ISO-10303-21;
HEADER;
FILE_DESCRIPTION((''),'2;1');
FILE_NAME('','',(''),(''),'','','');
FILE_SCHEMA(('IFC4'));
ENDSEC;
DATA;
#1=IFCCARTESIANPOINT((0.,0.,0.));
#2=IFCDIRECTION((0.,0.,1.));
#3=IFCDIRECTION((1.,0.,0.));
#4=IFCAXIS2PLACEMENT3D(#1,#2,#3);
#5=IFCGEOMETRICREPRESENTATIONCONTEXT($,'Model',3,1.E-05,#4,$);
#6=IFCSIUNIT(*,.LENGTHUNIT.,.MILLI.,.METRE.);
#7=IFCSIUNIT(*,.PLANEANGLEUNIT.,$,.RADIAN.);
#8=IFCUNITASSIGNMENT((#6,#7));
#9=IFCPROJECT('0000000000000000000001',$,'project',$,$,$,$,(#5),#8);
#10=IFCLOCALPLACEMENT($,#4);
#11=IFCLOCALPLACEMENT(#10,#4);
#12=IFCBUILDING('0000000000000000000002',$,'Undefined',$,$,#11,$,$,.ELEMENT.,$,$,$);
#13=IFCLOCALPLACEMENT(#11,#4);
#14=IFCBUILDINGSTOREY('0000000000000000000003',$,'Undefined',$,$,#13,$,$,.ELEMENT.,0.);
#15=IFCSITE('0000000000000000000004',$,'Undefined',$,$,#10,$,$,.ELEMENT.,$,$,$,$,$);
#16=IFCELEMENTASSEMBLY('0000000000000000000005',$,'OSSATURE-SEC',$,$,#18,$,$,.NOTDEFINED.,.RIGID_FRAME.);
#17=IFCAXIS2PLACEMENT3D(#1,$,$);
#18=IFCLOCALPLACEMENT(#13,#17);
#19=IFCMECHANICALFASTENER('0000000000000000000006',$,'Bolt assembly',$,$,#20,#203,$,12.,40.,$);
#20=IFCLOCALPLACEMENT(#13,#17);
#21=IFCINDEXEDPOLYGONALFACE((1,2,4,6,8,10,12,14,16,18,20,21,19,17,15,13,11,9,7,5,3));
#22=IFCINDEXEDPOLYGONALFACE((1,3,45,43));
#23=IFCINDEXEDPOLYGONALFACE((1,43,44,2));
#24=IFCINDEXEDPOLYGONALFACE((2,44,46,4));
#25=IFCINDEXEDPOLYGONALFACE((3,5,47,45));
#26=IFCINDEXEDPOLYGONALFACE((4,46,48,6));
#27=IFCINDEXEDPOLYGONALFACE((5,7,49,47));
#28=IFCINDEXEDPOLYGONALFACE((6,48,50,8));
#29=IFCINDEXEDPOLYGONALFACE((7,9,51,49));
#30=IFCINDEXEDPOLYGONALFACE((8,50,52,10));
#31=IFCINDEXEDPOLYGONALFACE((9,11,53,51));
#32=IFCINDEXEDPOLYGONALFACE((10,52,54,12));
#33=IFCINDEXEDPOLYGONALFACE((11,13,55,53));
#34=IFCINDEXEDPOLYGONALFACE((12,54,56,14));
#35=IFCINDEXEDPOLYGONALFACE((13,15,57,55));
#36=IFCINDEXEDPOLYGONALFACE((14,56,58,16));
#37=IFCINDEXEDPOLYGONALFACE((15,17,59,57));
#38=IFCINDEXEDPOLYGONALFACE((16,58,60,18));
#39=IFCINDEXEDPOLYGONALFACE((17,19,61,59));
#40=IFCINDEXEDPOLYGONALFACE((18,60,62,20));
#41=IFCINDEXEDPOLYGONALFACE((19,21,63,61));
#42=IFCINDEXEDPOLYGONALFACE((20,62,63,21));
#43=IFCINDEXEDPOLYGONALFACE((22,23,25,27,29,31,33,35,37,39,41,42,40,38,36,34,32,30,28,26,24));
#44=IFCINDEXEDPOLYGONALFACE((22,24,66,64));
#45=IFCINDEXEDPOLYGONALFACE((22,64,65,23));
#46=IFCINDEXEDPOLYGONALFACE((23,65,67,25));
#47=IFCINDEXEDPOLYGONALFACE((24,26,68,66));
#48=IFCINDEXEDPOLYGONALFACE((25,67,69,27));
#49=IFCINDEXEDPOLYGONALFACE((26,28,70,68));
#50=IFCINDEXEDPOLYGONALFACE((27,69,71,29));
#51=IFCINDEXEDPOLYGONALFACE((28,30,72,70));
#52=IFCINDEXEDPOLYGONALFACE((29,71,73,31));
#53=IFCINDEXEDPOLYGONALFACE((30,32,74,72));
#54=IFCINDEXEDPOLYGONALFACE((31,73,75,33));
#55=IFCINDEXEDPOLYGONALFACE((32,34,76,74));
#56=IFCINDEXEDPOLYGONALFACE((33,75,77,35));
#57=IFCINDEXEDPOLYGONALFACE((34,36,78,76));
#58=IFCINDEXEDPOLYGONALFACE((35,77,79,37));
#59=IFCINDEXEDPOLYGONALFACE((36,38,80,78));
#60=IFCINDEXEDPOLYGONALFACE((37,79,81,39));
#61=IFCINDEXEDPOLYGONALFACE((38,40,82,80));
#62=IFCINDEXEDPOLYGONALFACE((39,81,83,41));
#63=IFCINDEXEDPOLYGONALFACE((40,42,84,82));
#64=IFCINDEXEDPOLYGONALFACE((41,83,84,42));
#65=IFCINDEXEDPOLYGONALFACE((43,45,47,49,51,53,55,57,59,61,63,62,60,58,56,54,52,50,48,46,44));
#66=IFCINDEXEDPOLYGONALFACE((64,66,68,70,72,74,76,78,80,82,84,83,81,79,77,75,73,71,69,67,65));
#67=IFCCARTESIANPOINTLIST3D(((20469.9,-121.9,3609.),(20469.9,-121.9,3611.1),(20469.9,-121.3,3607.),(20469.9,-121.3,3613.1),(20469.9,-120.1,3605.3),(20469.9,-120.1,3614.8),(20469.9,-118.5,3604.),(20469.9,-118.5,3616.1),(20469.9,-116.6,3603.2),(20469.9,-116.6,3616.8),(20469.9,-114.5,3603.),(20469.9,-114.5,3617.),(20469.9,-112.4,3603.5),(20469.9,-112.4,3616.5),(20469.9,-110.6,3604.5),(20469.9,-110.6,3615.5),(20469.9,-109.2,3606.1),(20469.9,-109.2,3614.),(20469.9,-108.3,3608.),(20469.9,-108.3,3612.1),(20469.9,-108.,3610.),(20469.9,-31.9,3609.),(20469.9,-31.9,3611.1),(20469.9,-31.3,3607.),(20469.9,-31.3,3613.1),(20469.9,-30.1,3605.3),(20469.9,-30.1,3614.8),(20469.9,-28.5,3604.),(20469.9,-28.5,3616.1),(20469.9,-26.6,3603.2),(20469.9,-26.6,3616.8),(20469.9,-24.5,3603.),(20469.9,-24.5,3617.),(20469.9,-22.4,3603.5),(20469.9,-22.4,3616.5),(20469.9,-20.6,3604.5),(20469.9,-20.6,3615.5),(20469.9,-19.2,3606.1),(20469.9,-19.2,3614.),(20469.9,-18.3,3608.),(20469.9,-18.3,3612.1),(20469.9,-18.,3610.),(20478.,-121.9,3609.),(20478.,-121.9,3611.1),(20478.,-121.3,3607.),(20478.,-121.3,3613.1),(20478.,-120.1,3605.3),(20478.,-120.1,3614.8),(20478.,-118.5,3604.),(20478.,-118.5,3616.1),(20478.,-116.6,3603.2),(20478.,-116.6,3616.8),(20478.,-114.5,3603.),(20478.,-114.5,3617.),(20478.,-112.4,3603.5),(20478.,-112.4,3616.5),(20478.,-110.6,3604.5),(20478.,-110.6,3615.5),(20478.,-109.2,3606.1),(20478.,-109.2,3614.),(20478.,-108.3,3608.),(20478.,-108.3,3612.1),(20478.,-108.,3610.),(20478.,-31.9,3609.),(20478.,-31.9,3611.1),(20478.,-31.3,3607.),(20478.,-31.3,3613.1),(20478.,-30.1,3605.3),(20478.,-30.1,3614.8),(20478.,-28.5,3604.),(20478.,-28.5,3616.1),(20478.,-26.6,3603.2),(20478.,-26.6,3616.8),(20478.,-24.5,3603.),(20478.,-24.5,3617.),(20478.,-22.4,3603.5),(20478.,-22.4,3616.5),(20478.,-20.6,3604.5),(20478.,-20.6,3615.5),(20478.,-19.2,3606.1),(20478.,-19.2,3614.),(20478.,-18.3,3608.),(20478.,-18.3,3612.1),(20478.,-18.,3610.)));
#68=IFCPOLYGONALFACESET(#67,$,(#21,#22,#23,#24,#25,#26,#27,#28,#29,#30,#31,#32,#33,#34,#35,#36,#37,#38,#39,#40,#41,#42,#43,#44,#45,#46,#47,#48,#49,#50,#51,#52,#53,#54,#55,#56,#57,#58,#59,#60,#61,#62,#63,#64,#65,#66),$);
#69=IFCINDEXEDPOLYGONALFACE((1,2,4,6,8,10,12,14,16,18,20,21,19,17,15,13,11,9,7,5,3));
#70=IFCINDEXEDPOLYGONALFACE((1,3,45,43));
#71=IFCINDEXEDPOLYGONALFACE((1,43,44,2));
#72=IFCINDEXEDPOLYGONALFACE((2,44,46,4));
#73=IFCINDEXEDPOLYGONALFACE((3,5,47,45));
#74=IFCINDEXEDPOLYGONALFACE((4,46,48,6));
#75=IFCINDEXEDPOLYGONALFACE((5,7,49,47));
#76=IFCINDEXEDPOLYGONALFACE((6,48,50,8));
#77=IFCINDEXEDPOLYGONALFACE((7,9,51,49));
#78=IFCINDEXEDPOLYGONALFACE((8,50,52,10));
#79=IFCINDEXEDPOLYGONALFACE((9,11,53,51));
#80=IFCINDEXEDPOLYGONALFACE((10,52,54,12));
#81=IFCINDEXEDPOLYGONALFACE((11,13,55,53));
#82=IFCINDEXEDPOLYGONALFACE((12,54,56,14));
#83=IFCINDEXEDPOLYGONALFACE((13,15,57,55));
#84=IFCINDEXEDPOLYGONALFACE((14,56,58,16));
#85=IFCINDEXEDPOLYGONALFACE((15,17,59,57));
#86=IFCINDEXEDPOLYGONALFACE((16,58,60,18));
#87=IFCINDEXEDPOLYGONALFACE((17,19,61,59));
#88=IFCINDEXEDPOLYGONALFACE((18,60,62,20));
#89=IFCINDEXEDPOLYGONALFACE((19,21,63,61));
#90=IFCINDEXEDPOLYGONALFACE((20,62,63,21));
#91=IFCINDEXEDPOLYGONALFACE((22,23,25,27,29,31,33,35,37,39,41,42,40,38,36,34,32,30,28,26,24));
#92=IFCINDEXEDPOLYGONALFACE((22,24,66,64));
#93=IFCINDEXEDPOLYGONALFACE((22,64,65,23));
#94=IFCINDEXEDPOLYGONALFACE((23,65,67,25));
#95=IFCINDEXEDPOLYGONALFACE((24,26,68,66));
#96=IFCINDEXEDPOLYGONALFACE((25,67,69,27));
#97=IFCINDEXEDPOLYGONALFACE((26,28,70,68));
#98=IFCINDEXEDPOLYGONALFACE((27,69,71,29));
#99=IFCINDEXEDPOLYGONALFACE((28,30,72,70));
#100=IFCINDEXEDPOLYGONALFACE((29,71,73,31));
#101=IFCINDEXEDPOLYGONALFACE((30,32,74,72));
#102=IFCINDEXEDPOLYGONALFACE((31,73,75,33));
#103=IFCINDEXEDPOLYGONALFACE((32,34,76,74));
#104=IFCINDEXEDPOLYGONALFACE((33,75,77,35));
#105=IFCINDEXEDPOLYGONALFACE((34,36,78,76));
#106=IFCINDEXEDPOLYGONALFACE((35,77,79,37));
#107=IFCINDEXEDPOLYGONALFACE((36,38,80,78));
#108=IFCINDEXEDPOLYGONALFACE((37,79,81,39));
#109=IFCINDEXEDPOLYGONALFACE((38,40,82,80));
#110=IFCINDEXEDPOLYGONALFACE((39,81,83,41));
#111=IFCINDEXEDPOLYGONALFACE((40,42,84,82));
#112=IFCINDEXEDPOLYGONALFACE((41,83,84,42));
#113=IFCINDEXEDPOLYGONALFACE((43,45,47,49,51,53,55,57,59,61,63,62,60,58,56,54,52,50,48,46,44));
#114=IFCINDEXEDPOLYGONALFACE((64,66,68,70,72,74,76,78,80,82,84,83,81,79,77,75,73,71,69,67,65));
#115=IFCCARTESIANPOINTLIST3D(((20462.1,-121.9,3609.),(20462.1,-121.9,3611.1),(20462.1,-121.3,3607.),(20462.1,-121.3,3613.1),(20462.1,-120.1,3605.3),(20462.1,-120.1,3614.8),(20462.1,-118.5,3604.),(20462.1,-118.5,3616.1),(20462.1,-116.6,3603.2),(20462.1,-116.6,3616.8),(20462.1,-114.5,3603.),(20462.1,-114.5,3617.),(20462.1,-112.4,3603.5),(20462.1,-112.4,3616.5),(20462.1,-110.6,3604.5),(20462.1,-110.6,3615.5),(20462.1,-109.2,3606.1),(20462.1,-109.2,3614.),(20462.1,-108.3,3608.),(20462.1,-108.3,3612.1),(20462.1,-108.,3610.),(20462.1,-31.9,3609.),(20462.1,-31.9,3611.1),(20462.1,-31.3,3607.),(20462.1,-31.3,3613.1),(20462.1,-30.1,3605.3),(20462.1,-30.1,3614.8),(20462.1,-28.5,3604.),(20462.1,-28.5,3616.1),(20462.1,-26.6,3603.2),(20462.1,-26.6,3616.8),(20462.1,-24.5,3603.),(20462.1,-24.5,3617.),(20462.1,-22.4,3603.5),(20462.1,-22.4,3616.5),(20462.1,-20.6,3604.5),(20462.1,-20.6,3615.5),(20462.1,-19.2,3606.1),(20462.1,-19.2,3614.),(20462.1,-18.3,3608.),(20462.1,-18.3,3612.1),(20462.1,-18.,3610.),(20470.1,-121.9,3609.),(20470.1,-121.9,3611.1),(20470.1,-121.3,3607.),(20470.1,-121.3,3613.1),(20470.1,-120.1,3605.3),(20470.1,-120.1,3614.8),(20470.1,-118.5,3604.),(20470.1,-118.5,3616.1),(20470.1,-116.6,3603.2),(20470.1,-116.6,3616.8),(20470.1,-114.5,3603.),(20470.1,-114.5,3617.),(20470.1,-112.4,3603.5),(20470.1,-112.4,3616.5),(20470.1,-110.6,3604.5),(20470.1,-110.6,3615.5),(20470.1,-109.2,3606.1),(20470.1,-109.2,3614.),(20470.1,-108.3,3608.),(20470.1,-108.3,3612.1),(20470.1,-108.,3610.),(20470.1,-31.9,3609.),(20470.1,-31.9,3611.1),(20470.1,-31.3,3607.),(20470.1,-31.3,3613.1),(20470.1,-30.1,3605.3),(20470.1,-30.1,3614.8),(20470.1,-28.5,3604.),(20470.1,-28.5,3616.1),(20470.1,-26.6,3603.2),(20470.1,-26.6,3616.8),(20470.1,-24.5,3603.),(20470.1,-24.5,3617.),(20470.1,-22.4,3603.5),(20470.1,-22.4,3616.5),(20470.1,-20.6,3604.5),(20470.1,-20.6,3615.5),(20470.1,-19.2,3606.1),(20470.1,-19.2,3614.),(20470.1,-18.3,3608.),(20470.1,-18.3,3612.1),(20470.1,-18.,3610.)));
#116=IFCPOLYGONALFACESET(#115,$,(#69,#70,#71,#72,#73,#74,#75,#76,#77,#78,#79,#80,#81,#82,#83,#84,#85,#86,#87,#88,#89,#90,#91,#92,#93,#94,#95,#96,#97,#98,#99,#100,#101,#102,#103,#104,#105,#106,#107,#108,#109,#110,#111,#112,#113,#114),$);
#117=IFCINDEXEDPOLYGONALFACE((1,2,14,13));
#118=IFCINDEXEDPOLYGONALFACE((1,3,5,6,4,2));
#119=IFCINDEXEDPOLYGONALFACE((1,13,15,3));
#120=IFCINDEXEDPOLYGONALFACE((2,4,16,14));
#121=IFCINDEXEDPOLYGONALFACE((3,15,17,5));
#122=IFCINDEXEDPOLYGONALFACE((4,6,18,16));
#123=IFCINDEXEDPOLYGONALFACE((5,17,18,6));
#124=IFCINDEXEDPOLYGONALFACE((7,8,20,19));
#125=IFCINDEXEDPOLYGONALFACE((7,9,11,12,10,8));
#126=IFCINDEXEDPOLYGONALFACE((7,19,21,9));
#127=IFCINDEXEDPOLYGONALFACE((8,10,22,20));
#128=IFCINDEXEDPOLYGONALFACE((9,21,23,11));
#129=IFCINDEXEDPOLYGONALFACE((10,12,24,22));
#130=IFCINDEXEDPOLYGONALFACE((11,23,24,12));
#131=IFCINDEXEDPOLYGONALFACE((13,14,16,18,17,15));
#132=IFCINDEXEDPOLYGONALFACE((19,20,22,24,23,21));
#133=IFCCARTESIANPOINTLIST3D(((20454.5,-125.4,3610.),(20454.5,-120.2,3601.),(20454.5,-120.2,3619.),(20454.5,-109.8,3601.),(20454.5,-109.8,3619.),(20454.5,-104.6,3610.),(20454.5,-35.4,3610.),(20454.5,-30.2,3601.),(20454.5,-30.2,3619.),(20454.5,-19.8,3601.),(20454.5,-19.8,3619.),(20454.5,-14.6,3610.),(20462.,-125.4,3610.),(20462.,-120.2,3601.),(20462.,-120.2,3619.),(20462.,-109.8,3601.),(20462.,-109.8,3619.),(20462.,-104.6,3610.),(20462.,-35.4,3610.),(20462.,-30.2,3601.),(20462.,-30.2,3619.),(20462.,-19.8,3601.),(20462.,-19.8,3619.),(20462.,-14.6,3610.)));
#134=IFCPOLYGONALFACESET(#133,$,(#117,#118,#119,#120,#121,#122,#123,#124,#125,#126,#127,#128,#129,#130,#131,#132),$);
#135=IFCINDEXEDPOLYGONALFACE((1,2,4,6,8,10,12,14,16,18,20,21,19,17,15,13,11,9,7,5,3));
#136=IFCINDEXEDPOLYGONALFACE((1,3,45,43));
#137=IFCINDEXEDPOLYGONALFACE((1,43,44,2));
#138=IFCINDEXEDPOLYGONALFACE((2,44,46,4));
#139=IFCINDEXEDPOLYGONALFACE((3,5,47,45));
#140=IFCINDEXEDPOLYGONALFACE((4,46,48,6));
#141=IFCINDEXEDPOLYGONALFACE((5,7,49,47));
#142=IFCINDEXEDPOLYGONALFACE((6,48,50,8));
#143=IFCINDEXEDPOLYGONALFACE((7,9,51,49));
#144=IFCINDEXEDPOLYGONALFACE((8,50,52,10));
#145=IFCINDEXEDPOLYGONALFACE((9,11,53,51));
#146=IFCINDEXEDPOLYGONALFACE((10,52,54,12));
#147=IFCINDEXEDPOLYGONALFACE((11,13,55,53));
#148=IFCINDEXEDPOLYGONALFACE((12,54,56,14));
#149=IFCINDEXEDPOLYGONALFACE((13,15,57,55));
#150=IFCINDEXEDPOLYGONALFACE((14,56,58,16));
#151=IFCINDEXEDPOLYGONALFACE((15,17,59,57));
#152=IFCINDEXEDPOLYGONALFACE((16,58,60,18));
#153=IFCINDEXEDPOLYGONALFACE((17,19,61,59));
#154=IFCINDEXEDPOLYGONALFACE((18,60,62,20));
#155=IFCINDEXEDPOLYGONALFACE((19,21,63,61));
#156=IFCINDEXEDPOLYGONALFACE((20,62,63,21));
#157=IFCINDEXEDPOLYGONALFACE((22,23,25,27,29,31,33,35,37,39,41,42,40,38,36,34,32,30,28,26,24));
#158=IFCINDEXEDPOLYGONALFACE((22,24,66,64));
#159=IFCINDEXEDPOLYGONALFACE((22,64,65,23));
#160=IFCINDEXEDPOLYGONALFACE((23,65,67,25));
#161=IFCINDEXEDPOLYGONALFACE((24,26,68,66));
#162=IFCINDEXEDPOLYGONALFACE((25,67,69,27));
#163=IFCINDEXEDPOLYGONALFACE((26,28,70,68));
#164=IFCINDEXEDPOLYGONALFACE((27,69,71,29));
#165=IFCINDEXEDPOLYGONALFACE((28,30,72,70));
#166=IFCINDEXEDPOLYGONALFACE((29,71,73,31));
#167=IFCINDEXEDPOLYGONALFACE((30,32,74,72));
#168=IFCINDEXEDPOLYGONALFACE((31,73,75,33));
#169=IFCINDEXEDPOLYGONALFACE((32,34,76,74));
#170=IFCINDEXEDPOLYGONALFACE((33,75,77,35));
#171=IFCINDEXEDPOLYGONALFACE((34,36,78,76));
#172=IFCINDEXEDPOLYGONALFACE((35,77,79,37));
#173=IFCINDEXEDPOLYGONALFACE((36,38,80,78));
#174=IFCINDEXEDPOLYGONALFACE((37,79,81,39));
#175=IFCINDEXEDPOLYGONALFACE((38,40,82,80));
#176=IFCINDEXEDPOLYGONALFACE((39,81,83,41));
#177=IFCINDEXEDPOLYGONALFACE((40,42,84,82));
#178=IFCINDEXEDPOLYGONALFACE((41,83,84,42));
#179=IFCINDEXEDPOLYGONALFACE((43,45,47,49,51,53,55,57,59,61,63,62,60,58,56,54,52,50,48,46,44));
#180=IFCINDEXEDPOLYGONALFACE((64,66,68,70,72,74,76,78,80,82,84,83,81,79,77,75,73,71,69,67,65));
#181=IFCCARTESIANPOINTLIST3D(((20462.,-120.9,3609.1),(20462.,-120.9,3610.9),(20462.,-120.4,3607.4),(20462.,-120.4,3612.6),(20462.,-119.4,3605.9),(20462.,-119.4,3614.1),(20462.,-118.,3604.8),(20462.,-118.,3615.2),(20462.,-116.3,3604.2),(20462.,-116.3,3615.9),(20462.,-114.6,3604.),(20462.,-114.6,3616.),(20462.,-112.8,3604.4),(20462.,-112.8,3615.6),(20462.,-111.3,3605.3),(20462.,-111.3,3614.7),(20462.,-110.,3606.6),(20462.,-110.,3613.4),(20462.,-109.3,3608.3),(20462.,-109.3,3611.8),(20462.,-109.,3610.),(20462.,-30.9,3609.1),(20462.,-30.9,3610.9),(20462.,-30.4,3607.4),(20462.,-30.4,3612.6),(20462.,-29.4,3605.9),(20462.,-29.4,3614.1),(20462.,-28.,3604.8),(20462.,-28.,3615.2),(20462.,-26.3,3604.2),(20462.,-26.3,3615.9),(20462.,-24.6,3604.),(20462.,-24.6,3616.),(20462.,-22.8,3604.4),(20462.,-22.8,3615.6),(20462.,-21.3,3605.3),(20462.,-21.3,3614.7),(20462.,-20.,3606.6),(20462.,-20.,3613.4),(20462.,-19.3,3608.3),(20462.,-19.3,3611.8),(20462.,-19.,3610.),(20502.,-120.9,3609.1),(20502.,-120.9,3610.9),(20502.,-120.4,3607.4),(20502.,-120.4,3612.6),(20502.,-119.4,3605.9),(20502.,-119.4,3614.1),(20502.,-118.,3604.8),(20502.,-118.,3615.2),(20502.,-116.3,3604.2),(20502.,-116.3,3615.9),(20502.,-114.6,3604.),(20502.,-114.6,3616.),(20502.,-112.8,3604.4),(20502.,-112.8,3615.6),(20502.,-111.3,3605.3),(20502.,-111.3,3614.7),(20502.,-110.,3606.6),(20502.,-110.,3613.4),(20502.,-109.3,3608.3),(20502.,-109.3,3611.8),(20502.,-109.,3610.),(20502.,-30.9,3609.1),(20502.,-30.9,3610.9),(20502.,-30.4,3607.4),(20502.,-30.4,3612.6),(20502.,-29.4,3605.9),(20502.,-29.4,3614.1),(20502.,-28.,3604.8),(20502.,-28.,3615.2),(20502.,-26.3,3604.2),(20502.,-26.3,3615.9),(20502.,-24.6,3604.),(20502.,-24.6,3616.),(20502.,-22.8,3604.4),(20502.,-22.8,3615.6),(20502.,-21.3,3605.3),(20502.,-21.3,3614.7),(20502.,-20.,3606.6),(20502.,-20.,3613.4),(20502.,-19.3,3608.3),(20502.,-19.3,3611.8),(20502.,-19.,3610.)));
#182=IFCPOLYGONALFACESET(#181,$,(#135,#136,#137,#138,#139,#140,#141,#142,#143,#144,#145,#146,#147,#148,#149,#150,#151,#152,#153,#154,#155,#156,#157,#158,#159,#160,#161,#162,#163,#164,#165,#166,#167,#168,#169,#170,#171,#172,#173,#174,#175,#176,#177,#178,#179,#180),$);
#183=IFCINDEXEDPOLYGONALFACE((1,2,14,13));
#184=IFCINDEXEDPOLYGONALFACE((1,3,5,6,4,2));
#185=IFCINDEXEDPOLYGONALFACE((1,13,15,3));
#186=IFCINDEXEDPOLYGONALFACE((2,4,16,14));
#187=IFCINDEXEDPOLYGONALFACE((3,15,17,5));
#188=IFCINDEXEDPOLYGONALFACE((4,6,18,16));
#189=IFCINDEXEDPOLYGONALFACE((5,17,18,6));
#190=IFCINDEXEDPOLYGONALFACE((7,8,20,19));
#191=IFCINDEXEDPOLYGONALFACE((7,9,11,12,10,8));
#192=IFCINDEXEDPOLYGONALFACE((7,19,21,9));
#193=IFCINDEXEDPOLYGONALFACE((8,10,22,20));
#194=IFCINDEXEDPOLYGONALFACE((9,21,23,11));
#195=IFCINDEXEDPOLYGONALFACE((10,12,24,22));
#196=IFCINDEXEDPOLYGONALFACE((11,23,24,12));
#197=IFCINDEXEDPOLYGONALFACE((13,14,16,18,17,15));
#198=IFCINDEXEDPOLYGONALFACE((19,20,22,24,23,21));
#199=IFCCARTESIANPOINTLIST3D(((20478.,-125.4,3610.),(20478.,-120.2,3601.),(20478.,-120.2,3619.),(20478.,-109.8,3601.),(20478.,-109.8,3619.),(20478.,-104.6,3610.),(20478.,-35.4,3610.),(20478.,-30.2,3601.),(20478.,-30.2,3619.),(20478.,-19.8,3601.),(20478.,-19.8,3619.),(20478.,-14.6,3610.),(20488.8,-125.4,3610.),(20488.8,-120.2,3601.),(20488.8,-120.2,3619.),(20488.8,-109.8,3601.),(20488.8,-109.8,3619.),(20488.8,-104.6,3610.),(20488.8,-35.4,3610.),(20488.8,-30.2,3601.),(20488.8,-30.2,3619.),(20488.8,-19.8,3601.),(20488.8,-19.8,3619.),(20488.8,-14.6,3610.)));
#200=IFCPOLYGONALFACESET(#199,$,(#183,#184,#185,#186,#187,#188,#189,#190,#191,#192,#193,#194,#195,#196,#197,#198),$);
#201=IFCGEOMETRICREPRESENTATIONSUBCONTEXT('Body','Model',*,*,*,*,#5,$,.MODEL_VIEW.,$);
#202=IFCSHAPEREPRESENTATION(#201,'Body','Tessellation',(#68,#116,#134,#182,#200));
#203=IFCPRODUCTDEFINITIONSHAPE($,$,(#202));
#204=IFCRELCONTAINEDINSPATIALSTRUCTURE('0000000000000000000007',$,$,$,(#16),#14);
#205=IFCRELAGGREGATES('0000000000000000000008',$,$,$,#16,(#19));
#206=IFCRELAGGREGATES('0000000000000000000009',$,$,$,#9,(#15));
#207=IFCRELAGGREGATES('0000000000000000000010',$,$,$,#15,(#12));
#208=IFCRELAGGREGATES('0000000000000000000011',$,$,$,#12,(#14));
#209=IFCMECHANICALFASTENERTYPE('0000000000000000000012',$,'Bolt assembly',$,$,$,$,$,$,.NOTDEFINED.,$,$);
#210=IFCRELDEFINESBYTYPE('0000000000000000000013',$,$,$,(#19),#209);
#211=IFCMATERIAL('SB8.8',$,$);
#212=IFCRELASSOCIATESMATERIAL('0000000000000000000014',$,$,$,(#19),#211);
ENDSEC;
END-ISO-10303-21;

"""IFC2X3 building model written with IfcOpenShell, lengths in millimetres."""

from ifc_helpers import new_model, si_unit, frame, origin_with_axes, origin_2d_with_axis, place, context, subcontext, project, spatial, polyline, circle, outline, extrude, source, transform, mapped, material, type_object, element, aggregate, save


model = new_model("IFC2X3")

# Units and contexts
model_context = context("Model", 3, precision=1e-05, world=origin_with_axes())
body_context = subcontext(model_context, "Body", "Model", "MODEL_VIEW")
ifc_project = project(units=[si_unit("LENGTHUNIT", "METRE", prefix="MILLI"), si_unit("PLANEANGLEUNIT", "RADIAN")], contexts=[model_context])

# Site, building, storey
site_placement = place(None, origin_with_axes())
site = spatial("IfcSite", under=ifc_project, at=site_placement, Name="Undefined", CompositionType="ELEMENT")
building_placement = place(site_placement, origin_with_axes())
building = spatial("IfcBuilding", under=site, at=building_placement, Name="Undefined", CompositionType="ELEMENT")
storey_placement = place(building_placement, origin_with_axes())
storey = spatial("IfcBuildingStorey", under=building, at=storey_placement, Name="Undefined", CompositionType="ELEMENT", Elevation=0.0)

# Element assembly
assembly_1_placement = place(storey_placement, origin_with_axes())
assembly_1 = element("IfcElementAssembly", 1, at=assembly_1_placement, inside=storey, Name="OSSATURE-SEC", AssemblyPlace="NOTDEFINED", PredefinedType="RIGID_FRAME")

# Mechanical fastener
ifc_material_1 = material(Name="SB8.8")
mechanical_fastener_type = type_object("IfcMechanicalFastenerType", Name="Bolt assembly")
shared_shape_1 = source(origin_with_axes(), body_context, "Body", "SweptSolid", [
    extrude(circle(Radius=7.0, at=origin_2d_with_axis()), frame((0.0, 0.2, 0.0), z_axis=(0.0, 1.0, 0.0), x_axis=(1.0, 0.0, 0.0)), (0.0, 0.0, 1.0), 8.1),
    extrude(circle(Radius=7.0, at=origin_2d_with_axis()), frame((0.0, -7.6, 0.0), z_axis=(0.0, 1.0, 0.0), x_axis=(1.0, 0.0, 0.0)), (0.0, 0.0, 1.0), 8.0),
    extrude(outline(polyline([(10.4, 0.0), (5.2, 9.0), (-5.2, 9.0), (-10.4, 0.0), (-5.2, -9.0), (5.2, -9.0), (10.4, 0.0)])), frame((0.0, -15.2, 0.0), z_axis=(0.0, 1.0, 0.0), x_axis=(1.0, 0.0, 0.0)), (0.0, 0.0, 1.0), 7.5),
    extrude(circle(Radius=6.0, at=origin_2d_with_axis()), frame((0.0, -7.7, 0.0), z_axis=(0.0, 1.0, 0.0), x_axis=(1.0, 0.0, 0.0)), (0.0, 0.0, 1.0), 40.0),
    extrude(outline(polyline([(10.4, 0.0), (5.2, 9.0), (-5.2, 9.0), (-10.4, 0.0), (-5.2, -9.0), (5.2, -9.0), (10.4, 0.0)])), frame((0.0, 8.3, 0.0), z_axis=(0.0, 1.0, 0.0), x_axis=(1.0, 0.0, 0.0)), (0.0, 0.0, 1.0), 10.8),
])
mechanical_fastener_1_placement = place(assembly_1_placement, frame((20469.7, -115.0, 3610.0), z_axis=(0.0, 0.0, -1.0), x_axis=(0.0, 1.0, 0.0)))
mechanical_fastener_1 = element("IfcMechanicalFastener", 2, at=mechanical_fastener_1_placement, type_object=mechanical_fastener_type, material=ifc_material_1, Name="Bolt assembly", NominalDiameter=12.0, NominalLength=40.0, context=body_context, shape_type="MappedRepresentation", body=[
    mapped(shared_shape_1, transform((0.0, 0.0, 0.0))),
    mapped(shared_shape_1, transform((90.0, 0.0, 0.0))),
])
aggregate(assembly_1, [mechanical_fastener_1])

save(model, "model.ifc")
